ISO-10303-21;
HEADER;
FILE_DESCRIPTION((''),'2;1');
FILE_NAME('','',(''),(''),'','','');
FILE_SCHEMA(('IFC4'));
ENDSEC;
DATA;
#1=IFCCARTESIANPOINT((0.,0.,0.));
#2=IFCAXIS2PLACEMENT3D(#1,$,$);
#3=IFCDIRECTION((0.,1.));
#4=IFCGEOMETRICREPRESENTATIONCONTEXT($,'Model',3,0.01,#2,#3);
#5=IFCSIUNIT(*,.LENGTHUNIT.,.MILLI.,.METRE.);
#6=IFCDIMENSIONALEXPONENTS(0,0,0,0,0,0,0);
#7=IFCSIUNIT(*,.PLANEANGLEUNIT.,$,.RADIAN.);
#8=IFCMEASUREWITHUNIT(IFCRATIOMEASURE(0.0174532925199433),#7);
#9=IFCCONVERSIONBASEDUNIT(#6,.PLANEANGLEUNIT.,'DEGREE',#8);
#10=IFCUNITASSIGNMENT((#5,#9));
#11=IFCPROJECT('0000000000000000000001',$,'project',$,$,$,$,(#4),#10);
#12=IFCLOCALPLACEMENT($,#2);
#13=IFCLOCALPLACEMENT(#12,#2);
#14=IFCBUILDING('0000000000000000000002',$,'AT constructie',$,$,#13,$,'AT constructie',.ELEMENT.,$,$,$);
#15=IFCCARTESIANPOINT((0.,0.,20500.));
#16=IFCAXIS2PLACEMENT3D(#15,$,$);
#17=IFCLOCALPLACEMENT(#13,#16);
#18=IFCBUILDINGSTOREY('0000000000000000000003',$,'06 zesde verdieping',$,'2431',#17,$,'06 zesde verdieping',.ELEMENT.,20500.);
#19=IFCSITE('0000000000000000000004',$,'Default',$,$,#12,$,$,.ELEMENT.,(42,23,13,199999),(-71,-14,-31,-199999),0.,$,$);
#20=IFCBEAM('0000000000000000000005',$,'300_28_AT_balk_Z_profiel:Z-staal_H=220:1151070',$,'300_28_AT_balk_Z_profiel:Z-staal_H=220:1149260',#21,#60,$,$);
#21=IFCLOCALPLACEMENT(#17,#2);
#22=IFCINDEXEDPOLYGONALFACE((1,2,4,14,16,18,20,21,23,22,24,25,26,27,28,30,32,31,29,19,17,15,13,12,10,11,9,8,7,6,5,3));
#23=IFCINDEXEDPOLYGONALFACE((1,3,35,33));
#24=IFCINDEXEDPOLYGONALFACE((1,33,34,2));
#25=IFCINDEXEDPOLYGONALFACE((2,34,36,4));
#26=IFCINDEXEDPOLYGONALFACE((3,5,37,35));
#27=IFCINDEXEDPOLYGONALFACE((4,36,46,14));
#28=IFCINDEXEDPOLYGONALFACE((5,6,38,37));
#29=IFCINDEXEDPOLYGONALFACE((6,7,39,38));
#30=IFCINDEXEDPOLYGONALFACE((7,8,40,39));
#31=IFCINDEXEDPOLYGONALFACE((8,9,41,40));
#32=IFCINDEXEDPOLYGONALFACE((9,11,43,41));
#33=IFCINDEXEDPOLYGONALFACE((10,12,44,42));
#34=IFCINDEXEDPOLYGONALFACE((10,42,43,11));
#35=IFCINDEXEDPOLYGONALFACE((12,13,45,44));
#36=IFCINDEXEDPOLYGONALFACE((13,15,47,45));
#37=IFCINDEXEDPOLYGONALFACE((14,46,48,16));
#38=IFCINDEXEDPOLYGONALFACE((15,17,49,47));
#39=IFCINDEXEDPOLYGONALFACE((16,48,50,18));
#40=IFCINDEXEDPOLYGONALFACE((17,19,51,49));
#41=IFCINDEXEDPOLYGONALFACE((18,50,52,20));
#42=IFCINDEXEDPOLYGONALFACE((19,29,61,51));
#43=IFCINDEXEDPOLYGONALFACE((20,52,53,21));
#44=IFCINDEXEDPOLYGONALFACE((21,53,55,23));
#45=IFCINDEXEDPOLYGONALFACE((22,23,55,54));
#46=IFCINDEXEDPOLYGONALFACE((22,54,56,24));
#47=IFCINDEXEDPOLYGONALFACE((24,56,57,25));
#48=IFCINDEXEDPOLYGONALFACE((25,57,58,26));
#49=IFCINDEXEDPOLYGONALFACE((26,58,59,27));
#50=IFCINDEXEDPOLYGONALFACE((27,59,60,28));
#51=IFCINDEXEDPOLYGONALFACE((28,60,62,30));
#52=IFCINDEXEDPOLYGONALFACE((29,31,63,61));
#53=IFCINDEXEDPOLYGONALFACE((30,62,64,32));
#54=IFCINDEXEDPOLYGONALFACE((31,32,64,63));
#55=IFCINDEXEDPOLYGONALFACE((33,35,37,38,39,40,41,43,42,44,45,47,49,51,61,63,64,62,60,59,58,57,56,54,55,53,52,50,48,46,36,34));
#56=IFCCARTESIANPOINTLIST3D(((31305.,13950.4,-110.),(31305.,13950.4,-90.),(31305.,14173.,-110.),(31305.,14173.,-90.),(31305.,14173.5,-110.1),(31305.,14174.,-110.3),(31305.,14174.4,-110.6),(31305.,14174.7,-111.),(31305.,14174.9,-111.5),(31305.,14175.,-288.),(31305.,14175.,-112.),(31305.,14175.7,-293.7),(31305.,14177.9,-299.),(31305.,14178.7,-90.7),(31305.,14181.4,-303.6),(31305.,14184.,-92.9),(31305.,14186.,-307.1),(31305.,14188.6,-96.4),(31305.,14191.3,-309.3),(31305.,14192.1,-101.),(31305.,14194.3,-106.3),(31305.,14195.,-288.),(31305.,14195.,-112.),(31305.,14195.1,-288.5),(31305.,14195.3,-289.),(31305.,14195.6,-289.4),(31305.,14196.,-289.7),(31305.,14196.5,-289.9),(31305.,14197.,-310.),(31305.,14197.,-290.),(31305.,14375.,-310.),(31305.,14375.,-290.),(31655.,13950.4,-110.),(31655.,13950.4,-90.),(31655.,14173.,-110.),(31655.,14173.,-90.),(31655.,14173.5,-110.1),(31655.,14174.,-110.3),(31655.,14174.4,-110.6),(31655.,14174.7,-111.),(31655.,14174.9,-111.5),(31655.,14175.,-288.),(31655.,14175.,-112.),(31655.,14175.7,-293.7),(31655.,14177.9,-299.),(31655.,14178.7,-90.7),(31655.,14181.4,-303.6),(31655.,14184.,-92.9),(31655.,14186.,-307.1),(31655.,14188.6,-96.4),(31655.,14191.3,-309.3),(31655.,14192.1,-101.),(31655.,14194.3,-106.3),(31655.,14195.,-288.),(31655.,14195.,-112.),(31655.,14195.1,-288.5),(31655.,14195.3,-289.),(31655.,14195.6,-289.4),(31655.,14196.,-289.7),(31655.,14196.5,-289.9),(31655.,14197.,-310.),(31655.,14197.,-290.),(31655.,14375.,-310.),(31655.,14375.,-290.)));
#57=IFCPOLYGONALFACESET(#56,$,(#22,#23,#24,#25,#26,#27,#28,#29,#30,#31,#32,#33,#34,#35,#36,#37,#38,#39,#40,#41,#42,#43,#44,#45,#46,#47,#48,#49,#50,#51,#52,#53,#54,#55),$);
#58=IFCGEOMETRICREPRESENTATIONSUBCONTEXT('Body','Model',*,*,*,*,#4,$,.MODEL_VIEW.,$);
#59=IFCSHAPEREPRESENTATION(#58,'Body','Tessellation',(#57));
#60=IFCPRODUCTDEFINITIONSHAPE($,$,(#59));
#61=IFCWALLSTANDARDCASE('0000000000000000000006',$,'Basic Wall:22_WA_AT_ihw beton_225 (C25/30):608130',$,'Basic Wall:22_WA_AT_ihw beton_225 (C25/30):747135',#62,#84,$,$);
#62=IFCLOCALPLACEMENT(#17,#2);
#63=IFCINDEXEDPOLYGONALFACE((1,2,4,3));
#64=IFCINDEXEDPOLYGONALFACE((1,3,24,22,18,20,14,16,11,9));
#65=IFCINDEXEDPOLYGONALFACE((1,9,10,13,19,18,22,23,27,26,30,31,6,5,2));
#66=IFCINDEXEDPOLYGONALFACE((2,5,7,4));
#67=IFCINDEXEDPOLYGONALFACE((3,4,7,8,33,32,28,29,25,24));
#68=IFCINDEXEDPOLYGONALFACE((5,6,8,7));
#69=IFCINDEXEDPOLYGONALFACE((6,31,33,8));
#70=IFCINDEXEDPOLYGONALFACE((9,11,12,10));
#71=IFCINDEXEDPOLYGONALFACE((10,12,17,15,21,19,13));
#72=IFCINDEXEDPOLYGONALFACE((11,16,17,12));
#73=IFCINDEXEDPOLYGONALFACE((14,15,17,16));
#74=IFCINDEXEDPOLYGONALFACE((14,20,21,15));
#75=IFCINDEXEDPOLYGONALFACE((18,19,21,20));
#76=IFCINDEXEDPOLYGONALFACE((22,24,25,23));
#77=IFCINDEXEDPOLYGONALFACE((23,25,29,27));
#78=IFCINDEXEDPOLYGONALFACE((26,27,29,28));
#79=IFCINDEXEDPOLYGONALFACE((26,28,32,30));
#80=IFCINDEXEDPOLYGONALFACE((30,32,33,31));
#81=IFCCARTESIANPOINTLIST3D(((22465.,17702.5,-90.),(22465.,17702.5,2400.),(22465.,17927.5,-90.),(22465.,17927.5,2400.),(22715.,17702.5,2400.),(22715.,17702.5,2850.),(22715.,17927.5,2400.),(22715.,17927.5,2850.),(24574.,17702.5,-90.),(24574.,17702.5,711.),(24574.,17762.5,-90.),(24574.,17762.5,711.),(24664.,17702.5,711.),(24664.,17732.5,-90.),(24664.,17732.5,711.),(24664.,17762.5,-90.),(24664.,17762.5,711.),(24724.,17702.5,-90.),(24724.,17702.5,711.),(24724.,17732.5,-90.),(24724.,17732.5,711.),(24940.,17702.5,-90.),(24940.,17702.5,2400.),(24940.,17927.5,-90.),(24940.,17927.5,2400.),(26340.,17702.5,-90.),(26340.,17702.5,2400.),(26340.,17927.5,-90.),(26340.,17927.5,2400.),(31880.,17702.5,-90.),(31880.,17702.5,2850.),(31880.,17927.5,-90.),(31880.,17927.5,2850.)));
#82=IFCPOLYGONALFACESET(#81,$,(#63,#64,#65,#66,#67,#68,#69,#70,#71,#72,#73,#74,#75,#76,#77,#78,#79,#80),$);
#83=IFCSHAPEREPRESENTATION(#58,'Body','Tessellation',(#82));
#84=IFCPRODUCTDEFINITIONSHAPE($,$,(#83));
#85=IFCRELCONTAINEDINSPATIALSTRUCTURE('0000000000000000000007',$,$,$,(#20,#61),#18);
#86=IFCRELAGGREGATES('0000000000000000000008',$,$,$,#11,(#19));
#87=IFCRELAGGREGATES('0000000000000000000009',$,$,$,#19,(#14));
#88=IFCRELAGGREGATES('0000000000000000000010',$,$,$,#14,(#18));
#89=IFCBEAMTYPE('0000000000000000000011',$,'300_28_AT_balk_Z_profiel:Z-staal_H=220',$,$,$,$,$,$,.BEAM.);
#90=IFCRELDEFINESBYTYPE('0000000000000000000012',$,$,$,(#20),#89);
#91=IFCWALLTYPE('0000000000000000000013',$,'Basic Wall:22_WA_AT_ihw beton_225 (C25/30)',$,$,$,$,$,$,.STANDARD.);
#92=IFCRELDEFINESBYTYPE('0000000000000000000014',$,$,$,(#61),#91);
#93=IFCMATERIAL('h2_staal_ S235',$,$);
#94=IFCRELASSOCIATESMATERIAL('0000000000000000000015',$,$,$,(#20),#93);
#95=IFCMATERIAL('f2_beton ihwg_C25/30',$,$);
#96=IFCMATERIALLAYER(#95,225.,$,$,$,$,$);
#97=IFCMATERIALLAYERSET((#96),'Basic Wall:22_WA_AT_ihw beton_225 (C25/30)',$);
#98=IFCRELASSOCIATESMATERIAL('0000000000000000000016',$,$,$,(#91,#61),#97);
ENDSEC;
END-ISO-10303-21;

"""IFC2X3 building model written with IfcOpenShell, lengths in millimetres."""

from ifc_helpers import new_model, entity, si_unit, converted_unit, direction, frame, frame_2d, origin, origin_2d_with_axis, place, context, subcontext, project, spatial, polyline, circle_curve, parameter, trimmed, segment, composite_curve, rectangle, outline, extrude, material, layer, layer_set, layer_usage, type_object, element, save


model = new_model("IFC2X3")

# Units and contexts
model_context = context("Model", 3, precision=0.01, world=origin(), true_north=direction((0.0, 1.0)))
body_context = subcontext(model_context, "Body", "Model", "MODEL_VIEW")
ifc_project = project(units=[si_unit("LENGTHUNIT", "METRE", prefix="MILLI"), converted_unit("PLANEANGLEUNIT", "DEGREE", entity("IfcRatioMeasure", 0.0174532925199433), si_unit("PLANEANGLEUNIT", "RADIAN"), dimensions=[0, 0, 0, 0, 0, 0, 0])], contexts=[model_context])

# Site, building, storey
site_placement = place(None, origin())
site = spatial("IfcSite", under=ifc_project, at=site_placement, Name="Default", CompositionType="ELEMENT", RefLatitude=(42, 23, 13, 199999), RefLongitude=(-71, -14, -31, -199999), RefElevation=0.0)
building_placement = place(site_placement, origin())
building = spatial("IfcBuilding", under=site, at=building_placement, Name="AT constructie", LongName="AT constructie", CompositionType="ELEMENT")
storey_placement = place(building_placement, frame((0.0, 0.0, 20500.0)))
storey = spatial("IfcBuildingStorey", under=building, at=storey_placement, Name="06 zesde verdieping", ObjectType="2431", LongName="06 zesde verdieping", CompositionType="ELEMENT", Elevation=20500.0)

# Beam
ifc_material_1 = material(Name="h2_staal_ S235")
beam_type_1 = type_object("IfcBeamType", Name="300_28_AT_balk_Z_profiel:Z-staal_H=220", PredefinedType="BEAM")
beam_1_placement = place(storey_placement, frame((31655.0, 14175.0, -90.0), z_axis=(0.0, 0.0, 1.0), x_axis=(-1.0, 0.0, 0.0)))
element("IfcBeam", 1, at=beam_1_placement, inside=storey, type_object=beam_type_1, material=ifc_material_1, Name="300_28_AT_balk_Z_profiel:Z-staal_H=220:1151070", ObjectType="300_28_AT_balk_Z_profiel:Z-staal_H=220:1149260", context=body_context, shape_type="SweptSolid", body=[
    extrude(outline(composite_curve([segment(polyline([(90.0, -197.4), (110.0, -197.4)]), True, "CONTINUOUS"), segment(polyline([(110.0, -197.4), (110.0, -19.4)]), True, "CONTINUOUS"), segment(trimmed(circle_curve(frame_2d((88.0, -19.4), x_axis=(1.0, 0.0)), 22.0), [parameter(0.0)], [parameter(90.0)], True, "PARAMETER"), True, "CONTINUOUS"), segment(polyline([(88.0, 2.6), (-88.0, 2.6)]), True, "CONTINUOUS"), segment(trimmed(circle_curve(frame_2d((-88.0, 4.6), x_axis=(0.0, -1.0)), 2.0), [parameter(270.0)], [parameter(0.0)], True, "PARAMETER"), False, "CONTINUOUS"), segment(polyline([(-90.0, 4.6), (-90.0, 227.2)]), True, "CONTINUOUS"), segment(polyline([(-90.0, 227.2), (-110.0, 227.2)]), True, "CONTINUOUS"), segment(polyline([(-110.0, 227.2), (-110.0, 4.6)]), True, "CONTINUOUS"), segment(trimmed(circle_curve(frame_2d((-88.0, 4.6), x_axis=(-1.0, 0.0)), 22.0), [parameter(0.0)], [parameter(90.0)], True, "PARAMETER"), True, "CONTINUOUS"), segment(polyline([(-88.0, -17.4), (88.0, -17.4)]), True, "CONTINUOUS"), segment(trimmed(circle_curve(frame_2d((88.0, -19.4), x_axis=(0.0, 1.0)), 2.0), [parameter(270.0)], [parameter(0.0)], True, "PARAMETER"), False, "CONTINUOUS"), segment(polyline([(90.0, -19.4), (90.0, -197.4)]), True, "CONTINUOUS")], self_intersect=False)), frame((0.0, -2.6, -110.0), z_axis=(1.0, 0.0, 0.0), x_axis=(0.0, 0.0, -1.0)), (0.0, 0.0, 1.0), 350.0),
])

# Wall, openings
ifc_material_2 = material(Name="f2_beton ihwg_C25/30")
ifc_layer = layer(ifc_material_2, 225.0)
ifc_layer_set = layer_set([ifc_layer], Name="Basic Wall:22_WA_AT_ihw beton_225 (C25/30)")
ifc_layer_usage = layer_usage(ifc_layer_set, "AXIS2", "NEGATIVE", 112.5)
wall_type = type_object("IfcWallType", Name="Basic Wall:22_WA_AT_ihw beton_225 (C25/30)", PredefinedType="STANDARD", material=ifc_layer_set)
wall_placement = place(storey_placement, frame((22465.0, 17815.0, -90.0)))
wall = element("IfcWallStandardCase", 2, at=wall_placement, inside=storey, type_object=wall_type, material=ifc_layer_usage, Name="Basic Wall:22_WA_AT_ihw beton_225 (C25/30):608130", ObjectType="Basic Wall:22_WA_AT_ihw beton_225 (C25/30):747135", context=body_context, shape_type="SweptSolid", body=[
    extrude(rectangle(XDim=9415.0, YDim=225.0, at=frame_2d((4707.5, 0.0), x_axis=(-1.0, 0.0))), origin(), (0.0, 0.0, 1.0), 2940.0),
])
opening_1_placement = place(wall_placement, origin())
element("IfcOpeningElement", 3, at=opening_1_placement, cuts=wall, ObjectType="Opening", context=body_context, shape_type="SweptSolid", body=[
    extrude(rectangle(XDim=2490.0, YDim=1400.0, at=frame_2d((0.0, 0.0), x_axis=(1.0, 0.0))), frame((3175.0, -1411.5, 1245.0), z_axis=(0.0, 1.0, 0.0), x_axis=(0.0, 0.0, -1.0)), (0.0, 0.0, 1.0), 3048.0),
])
opening_2_placement = place(wall_placement, origin())
element("IfcOpeningElement", 4, at=opening_2_placement, cuts=wall, ObjectType="Recess", context=body_context, shape_type="SweptSolid", body=[
    extrude(rectangle(XDim=801.0, YDim=90.0, at=origin_2d_with_axis()), frame((2154.0, -112.5, 400.5), z_axis=(0.0, 1.0, 0.0), x_axis=(0.0, 0.0, -1.0)), (0.0, 0.0, 1.0), 60.0),
])
opening_3_placement = place(wall_placement, origin())
element("IfcOpeningElement", 5, at=opening_3_placement, cuts=wall, ObjectType="Recess", context=body_context, shape_type="SweptSolid", body=[
    extrude(rectangle(XDim=801.0, YDim=60.0, at=frame_2d((0.0, 0.0), x_axis=(1.0, 0.0))), frame((2229.0, -112.5, 400.5), z_axis=(0.0, 1.0, 0.0), x_axis=(0.0, 0.0, -1.0)), (0.0, 0.0, 1.0), 30.0),
])
opening_4_placement = place(wall_placement, origin())
element("IfcOpeningElement", 6, at=opening_4_placement, cuts=wall, ObjectType="Opening", context=body_context, shape_type="SweptSolid", body=[
    extrude(rectangle(XDim=450.0, YDim=250.0, at=frame_2d((0.0, 0.0), x_axis=(0.0, 1.0))), frame((125.0, 112.5, 2715.0), z_axis=(0.0, -1.0, 0.0), x_axis=(-1.0, 0.0, 0.0)), (0.0, 0.0, 1.0), 225.0),
])

save(model, "model.ifc")
